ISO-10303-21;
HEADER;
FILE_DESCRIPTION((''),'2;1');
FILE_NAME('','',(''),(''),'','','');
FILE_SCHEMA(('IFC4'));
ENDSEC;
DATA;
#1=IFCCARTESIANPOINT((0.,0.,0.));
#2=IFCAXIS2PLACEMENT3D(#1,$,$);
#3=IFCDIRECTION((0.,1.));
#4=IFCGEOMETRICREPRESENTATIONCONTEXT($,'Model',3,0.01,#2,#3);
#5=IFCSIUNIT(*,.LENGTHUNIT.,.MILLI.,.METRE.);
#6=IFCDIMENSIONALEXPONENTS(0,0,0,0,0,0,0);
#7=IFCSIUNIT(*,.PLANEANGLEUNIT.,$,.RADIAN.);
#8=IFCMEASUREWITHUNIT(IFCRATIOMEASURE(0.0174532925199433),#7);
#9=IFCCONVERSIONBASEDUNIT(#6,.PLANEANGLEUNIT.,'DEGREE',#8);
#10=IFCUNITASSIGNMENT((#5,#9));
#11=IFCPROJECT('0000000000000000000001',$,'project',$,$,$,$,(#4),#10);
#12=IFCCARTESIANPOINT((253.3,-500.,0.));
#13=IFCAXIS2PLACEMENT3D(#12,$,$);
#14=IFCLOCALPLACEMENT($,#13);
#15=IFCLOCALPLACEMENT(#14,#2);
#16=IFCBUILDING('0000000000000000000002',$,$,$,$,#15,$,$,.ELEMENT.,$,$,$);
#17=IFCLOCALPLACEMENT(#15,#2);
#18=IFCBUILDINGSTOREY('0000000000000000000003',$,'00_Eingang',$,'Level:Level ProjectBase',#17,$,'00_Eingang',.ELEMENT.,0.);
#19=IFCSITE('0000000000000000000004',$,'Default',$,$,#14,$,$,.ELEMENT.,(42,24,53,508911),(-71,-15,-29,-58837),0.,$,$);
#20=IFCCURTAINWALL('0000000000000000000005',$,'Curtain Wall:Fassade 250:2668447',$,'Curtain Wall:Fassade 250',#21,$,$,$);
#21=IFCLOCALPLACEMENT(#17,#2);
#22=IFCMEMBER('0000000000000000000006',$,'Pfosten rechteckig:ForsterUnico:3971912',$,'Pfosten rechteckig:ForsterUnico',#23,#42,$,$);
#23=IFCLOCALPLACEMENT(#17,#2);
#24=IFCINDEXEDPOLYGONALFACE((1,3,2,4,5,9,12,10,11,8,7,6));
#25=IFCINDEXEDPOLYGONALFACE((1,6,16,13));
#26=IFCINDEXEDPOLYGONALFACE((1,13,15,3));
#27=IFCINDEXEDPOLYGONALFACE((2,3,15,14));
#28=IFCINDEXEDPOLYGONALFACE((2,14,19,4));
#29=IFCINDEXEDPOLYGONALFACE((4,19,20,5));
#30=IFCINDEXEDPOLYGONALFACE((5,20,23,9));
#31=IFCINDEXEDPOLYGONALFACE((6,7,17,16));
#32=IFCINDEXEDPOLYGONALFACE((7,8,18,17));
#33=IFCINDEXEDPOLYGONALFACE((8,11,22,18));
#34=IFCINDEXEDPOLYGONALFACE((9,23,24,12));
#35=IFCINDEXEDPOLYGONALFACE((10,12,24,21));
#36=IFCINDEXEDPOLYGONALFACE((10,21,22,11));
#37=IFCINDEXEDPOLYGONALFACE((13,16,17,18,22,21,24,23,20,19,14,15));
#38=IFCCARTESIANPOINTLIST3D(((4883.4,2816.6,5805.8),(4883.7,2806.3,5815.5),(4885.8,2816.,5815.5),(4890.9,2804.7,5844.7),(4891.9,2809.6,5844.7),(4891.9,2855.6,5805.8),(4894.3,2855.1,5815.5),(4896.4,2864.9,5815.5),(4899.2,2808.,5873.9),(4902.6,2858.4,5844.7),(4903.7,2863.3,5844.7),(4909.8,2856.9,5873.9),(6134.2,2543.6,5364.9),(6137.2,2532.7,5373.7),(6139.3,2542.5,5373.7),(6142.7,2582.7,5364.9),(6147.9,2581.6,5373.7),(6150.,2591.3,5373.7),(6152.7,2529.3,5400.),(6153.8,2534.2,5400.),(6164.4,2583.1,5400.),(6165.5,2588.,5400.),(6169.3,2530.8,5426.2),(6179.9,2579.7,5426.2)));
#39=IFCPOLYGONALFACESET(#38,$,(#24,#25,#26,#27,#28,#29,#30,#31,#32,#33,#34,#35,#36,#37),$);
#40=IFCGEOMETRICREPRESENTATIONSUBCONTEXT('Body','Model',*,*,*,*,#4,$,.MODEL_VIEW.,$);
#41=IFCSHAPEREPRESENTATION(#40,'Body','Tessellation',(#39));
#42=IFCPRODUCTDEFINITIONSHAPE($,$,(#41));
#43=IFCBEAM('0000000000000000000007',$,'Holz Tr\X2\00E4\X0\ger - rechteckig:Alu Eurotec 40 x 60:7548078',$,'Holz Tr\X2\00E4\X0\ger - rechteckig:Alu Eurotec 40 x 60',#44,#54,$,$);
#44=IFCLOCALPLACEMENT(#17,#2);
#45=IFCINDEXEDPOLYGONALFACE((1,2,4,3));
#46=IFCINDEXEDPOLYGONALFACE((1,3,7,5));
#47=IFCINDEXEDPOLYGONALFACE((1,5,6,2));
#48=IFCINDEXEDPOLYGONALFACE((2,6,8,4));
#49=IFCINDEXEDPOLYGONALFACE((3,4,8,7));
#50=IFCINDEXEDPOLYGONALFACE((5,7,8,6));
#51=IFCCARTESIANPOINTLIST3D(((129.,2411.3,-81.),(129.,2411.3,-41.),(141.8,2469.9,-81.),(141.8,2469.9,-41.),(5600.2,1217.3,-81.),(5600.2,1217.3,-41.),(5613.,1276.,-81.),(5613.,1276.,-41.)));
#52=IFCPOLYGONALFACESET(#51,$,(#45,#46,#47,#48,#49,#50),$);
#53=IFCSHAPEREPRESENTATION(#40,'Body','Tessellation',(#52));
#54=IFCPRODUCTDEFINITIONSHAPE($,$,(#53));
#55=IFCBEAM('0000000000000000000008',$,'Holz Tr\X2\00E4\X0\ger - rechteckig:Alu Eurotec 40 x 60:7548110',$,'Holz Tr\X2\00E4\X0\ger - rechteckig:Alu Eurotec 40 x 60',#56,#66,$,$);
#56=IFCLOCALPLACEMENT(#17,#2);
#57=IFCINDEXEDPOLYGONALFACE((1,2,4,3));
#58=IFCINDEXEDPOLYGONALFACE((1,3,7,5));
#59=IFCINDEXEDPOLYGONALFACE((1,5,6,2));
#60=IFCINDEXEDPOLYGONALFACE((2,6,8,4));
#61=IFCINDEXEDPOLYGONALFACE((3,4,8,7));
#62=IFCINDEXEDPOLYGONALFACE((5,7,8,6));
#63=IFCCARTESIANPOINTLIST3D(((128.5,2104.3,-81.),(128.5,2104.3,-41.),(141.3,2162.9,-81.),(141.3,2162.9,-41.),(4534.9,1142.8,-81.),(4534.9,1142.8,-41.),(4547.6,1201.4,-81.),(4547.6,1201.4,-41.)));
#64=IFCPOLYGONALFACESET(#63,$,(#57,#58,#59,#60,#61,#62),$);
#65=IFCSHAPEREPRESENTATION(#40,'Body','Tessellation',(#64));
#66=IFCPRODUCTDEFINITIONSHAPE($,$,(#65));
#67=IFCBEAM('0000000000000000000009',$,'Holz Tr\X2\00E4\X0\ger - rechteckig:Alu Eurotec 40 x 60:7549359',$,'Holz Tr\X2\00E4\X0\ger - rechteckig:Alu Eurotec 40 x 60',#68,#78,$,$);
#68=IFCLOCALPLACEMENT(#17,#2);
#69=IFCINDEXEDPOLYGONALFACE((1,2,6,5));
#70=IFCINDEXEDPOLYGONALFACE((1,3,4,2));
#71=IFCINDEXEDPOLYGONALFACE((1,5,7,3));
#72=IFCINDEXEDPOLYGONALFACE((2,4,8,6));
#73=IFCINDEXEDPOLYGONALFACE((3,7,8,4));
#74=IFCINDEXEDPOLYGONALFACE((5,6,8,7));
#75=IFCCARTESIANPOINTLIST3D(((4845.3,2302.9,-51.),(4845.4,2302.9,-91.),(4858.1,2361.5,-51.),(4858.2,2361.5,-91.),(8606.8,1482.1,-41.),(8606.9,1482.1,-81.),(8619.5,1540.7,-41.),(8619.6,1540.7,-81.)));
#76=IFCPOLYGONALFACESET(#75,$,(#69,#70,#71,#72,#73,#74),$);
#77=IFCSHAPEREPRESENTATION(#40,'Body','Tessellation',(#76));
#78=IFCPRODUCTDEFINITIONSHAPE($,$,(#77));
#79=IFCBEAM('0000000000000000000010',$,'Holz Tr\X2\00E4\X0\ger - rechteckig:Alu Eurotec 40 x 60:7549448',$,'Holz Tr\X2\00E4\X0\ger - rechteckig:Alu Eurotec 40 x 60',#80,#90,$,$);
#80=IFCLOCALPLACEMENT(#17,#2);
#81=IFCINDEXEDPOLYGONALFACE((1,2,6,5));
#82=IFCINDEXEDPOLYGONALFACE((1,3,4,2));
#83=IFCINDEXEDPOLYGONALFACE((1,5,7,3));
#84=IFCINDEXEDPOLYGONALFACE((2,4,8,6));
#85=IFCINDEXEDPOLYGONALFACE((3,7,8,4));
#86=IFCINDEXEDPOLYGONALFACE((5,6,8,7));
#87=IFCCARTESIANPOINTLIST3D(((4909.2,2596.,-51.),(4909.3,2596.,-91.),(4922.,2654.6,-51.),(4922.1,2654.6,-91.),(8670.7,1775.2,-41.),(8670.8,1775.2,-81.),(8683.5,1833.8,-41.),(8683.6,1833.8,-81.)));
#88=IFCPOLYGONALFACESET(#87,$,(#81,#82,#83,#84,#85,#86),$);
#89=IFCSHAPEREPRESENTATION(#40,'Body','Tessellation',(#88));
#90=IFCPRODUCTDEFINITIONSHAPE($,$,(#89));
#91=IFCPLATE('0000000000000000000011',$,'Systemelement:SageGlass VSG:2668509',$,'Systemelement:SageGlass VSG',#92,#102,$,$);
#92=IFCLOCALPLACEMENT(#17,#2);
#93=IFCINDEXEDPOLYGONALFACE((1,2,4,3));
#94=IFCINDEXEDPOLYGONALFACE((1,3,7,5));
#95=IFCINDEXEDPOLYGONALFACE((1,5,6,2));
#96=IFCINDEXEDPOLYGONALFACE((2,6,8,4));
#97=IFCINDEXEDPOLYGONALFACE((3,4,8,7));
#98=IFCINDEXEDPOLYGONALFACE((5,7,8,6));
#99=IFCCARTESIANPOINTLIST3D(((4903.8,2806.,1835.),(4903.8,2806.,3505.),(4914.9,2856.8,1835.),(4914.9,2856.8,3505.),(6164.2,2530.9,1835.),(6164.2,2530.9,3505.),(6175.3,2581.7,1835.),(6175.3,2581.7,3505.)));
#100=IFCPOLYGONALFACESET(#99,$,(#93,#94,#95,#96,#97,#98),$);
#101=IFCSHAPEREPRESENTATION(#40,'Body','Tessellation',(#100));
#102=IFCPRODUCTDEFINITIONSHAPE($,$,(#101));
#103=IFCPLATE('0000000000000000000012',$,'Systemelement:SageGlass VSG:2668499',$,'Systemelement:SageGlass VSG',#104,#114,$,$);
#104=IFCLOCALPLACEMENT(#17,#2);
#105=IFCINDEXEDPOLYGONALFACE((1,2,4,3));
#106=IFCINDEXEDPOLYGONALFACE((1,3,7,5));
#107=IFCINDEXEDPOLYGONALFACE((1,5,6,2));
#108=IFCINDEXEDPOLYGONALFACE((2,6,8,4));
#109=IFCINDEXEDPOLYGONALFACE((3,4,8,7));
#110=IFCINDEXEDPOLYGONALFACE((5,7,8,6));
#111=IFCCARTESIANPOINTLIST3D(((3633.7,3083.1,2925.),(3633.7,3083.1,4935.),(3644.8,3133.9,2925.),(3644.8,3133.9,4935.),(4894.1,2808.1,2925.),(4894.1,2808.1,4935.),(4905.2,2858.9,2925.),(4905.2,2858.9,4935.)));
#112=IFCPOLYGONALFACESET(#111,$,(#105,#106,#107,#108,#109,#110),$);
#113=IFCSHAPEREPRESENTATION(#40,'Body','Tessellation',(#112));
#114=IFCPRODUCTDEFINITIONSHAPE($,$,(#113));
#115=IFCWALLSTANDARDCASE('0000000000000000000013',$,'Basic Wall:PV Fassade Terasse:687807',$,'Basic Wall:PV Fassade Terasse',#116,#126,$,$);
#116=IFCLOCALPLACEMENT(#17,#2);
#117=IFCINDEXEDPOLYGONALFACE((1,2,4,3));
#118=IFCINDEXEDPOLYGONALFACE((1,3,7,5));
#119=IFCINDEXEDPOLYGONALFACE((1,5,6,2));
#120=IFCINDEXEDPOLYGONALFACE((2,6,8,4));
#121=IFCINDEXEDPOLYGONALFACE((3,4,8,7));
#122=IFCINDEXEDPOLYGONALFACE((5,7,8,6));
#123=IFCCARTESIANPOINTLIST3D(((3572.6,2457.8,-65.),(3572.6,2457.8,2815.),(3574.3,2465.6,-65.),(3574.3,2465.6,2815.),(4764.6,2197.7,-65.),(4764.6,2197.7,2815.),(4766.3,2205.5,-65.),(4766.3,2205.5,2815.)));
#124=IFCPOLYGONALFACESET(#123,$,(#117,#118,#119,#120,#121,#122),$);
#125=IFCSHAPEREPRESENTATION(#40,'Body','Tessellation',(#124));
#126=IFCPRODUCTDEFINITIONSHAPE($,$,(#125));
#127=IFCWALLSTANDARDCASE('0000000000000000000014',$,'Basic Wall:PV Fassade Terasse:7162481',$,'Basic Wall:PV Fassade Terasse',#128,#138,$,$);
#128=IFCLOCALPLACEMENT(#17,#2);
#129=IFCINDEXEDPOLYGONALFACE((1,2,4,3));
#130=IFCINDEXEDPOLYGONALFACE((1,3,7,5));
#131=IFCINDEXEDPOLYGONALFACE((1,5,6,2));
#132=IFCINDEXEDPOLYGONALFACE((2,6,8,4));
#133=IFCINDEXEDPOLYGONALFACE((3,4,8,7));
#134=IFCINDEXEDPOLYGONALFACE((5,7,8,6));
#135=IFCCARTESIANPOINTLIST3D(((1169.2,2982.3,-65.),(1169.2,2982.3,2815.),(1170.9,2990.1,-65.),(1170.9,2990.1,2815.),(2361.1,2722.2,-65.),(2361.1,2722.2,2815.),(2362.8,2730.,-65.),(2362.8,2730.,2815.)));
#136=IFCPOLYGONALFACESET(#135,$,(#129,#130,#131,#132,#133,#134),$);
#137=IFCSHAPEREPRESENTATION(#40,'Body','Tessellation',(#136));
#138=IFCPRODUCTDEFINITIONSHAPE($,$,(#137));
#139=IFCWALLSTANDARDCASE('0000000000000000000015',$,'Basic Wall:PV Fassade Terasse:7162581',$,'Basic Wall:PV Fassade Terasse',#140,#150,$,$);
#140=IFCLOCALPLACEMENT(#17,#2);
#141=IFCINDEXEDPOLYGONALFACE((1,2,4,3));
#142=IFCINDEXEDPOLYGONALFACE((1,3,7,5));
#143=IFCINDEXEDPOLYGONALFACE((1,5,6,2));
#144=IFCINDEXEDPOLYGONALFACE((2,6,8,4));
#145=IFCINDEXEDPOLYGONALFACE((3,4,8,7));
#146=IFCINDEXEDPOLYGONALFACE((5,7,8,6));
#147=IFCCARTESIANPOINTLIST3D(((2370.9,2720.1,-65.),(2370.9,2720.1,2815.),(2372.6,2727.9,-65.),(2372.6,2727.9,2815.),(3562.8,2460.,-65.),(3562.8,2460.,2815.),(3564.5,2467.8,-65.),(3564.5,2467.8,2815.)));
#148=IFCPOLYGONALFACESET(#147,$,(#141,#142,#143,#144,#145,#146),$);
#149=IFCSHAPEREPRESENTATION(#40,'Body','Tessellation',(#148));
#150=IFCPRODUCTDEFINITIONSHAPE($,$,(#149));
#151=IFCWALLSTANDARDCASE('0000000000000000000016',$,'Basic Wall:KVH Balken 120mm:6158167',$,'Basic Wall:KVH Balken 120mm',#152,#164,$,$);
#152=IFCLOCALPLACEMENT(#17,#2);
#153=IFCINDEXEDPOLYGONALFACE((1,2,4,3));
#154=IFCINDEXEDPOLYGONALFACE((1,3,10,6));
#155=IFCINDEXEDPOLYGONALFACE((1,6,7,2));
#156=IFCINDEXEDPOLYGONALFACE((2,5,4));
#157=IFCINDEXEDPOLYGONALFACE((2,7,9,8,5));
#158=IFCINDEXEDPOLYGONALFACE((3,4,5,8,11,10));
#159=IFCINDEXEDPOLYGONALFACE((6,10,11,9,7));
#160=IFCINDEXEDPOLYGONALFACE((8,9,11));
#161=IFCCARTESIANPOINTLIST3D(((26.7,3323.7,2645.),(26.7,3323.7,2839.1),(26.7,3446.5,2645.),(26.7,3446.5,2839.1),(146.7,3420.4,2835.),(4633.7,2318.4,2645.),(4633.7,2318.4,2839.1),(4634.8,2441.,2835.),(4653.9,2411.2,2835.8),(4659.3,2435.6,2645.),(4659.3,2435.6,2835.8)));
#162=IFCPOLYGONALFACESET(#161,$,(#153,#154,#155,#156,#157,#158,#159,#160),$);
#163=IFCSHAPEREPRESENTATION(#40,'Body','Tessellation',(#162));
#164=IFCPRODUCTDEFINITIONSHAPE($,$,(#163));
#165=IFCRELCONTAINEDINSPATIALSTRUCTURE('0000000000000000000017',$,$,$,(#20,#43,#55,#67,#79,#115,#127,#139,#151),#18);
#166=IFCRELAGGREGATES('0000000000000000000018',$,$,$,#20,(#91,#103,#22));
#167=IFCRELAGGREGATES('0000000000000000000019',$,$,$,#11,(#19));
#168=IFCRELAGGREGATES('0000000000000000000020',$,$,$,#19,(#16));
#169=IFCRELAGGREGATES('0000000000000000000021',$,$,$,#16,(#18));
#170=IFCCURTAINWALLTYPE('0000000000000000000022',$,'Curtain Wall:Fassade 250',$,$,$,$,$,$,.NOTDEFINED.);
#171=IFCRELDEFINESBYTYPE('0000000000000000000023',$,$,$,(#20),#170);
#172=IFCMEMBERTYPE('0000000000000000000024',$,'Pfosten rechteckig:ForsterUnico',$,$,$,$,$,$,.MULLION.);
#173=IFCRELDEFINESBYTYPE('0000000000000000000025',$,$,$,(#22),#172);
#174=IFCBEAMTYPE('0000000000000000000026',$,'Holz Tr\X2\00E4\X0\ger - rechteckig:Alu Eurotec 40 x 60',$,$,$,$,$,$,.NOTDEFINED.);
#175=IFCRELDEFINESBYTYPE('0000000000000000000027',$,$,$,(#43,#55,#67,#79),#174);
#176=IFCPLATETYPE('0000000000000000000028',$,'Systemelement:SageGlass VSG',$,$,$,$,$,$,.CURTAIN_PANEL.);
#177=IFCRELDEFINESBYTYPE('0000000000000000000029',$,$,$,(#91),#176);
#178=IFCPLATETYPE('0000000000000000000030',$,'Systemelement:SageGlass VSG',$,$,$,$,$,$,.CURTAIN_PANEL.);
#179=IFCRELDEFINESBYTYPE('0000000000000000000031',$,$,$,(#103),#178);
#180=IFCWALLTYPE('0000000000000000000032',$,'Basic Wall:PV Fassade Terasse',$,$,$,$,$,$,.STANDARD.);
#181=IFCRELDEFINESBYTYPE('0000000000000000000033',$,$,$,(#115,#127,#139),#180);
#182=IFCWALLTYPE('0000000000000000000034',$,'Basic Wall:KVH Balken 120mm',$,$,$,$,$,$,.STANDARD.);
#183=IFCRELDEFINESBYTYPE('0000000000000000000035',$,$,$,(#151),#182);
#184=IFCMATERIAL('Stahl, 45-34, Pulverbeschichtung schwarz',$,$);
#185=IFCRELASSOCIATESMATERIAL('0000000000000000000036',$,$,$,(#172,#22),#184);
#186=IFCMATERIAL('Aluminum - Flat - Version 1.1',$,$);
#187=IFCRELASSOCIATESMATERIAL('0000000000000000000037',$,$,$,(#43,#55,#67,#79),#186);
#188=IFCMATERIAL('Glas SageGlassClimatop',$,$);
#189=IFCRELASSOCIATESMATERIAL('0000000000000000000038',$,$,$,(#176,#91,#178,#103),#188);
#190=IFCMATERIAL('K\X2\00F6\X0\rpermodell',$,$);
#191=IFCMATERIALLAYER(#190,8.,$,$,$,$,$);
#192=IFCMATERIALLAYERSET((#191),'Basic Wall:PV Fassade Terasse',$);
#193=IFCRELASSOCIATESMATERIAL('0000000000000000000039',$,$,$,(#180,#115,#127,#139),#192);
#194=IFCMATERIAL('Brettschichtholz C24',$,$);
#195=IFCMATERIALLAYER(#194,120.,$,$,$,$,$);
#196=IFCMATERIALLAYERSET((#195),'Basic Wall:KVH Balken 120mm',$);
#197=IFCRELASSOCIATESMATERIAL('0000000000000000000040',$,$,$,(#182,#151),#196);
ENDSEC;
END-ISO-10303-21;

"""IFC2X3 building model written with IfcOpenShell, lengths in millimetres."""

from ifc_helpers import new_model, entity, si_unit, converted_unit, direction, frame, frame_2d, origin, place, context, subcontext, project, spatial, polyline, rectangle, outline, extrude, clip, halfspace, bounded_halfspace, source, transform, mapped, material, layer, layer_set, layer_usage, type_object, type_shapes, element, aggregate, save


model = new_model("IFC2X3")

# Units and contexts
model_context = context("Model", 3, precision=0.01, world=origin(), true_north=direction((0.0, 1.0)))
body_context = subcontext(model_context, "Body", "Model", "MODEL_VIEW")
ifc_project = project(units=[si_unit("LENGTHUNIT", "METRE", prefix="MILLI"), converted_unit("PLANEANGLEUNIT", "DEGREE", entity("IfcRatioMeasure", 0.0174532925199433), si_unit("PLANEANGLEUNIT", "RADIAN"), dimensions=[0, 0, 0, 0, 0, 0, 0])], contexts=[model_context])

# Site, building, storey
site_placement = place(None, frame((253.3, -500.0, 0.0)))
site = spatial("IfcSite", under=ifc_project, at=site_placement, Name="Default", CompositionType="ELEMENT", RefLatitude=(42, 24, 53, 508911), RefLongitude=(-71, -15, -29, -58837), RefElevation=0.0)
building_placement = place(site_placement, origin())
building = spatial("IfcBuilding", under=site, at=building_placement, CompositionType="ELEMENT")
storey_placement = place(building_placement, origin())
storey = spatial("IfcBuildingStorey", under=building, at=storey_placement, Name="00_Eingang", ObjectType="Level:Level ProjectBase", LongName="00_Eingang", CompositionType="ELEMENT", Elevation=0.0)

# Curtain wall, member
curtain_wall_type = type_object("IfcCurtainWallType", Name="Curtain Wall:Fassade 250", PredefinedType="NOTDEFINED")
curtain_wall_placement = place(storey_placement, origin())
curtain_wall = element("IfcCurtainWall", 1, at=curtain_wall_placement, inside=storey, type_object=curtain_wall_type, Name="Curtain Wall:Fassade 250:2668447", ObjectType="Curtain Wall:Fassade 250")
ifc_material_1 = material(Name="Stahl, 45-34, Pulverbeschichtung schwarz")
member_type_1 = type_object("IfcMemberType", Name="Pfosten rechteckig:ForsterUnico", PredefinedType="MULLION", material=ifc_material_1)
shared_shape_1 = source(origin(), body_context, "Body", "Clipping", [
    clip(clip(extrude(outline(polyline([(-20.0, -28.3), (20.0, -28.3), (20.0, -18.3), (30.0, -18.3), (30.0, 11.7), (25.0, 11.7), (25.0, 41.7), (-25.0, 41.7), (-25.0, 11.7), (-30.0, 11.7), (-30.0, -18.3), (-20.0, -18.3), (-20.0, -28.3)])), frame((-41.7, 0.0, -1374.9), z_axis=(0.0, 0.0, 1.0), x_axis=(0.0, -1.0, 0.0)), (0.0, 0.0, 1.0), 1374.9), halfspace(frame((0.0, -304.8, -1374.9), z_axis=(-0.210106, 0.0, -0.977679), x_axis=(-0.977679, 0.0, 0.210106)), False)), halfspace(frame((0.0, -304.8, 0.0), z_axis=(-0.083458, 0.0, 0.996511), x_axis=(-0.996511, 0.0, -0.083458)), False)),
])
type_shapes(member_type_1, [shared_shape_1])
member_1_placement = place(storey_placement, frame((4904.5, 2832.4, 5873.9), z_axis=(-0.92378, 0.201585, 0.325568), x_axis=(0.318083, -0.069411, 0.945519)))
member_1 = element("IfcMember", 2, at=member_1_placement, type_object=member_type_1, material=ifc_material_1, Name="Pfosten rechteckig:ForsterUnico:3971912", ObjectType="Pfosten rechteckig:ForsterUnico", context=body_context, shape_type="MappedRepresentation", body=[
    mapped(shared_shape_1, transform((0.0, 0.0, 0.0), scale=1.0)),
])

# Beams
ifc_material_2 = material(Name="Aluminum - Flat - Version 1.1")
beam_type = type_object("IfcBeamType", Name="Holz Träger - rechteckig:Alu Eurotec 40 x 60", PredefinedType="NOTDEFINED")
beam_1_placement = place(storey_placement, frame((135.4, 2440.6, -41.0), z_axis=(0.0, 0.0, 1.0), x_axis=(0.977008, -0.213201, 0.0)))
element("IfcBeam", 3, at=beam_1_placement, inside=storey, type_object=beam_type, material=ifc_material_2, Name="Holz Träger - rechteckig:Alu Eurotec 40 x 60:7548078", ObjectType="Holz Träger - rechteckig:Alu Eurotec 40 x 60", context=body_context, shape_type="SweptSolid", body=[
    extrude(rectangle(XDim=40.0, YDim=60.0, at=frame_2d((0.0, 0.0), x_axis=(1.0, 0.0))), frame((0.0, 0.0, -20.0), z_axis=(1.0, 0.0, 0.0), x_axis=(0.0, 0.0, -1.0)), (0.0, 0.0, 1.0), 5600.0),
])
beam_2_placement = place(storey_placement, frame((134.9, 2133.6, -41.0), z_axis=(0.0, 0.0, 1.0), x_axis=(0.977008, -0.213201, 0.0)))
element("IfcBeam", 4, at=beam_2_placement, inside=storey, type_object=beam_type, material=ifc_material_2, Name="Holz Träger - rechteckig:Alu Eurotec 40 x 60:7548110", ObjectType="Holz Träger - rechteckig:Alu Eurotec 40 x 60", context=body_context, shape_type="SweptSolid", body=[
    extrude(rectangle(XDim=40.0, YDim=60.0, at=frame_2d((0.0, 0.0), x_axis=(1.0, 0.0))), frame((0.0, 0.0, -20.0), z_axis=(1.0, 0.0, 0.0), x_axis=(0.0, 0.0, -1.0)), (0.0, 0.0, 1.0), 4510.0),
])
beam_3_placement = place(storey_placement, frame((4851.7, 2332.2, -51.0), z_axis=(-0.002538, 0.000554, 0.999997), x_axis=(0.977005, -0.2132, 0.002597)))
element("IfcBeam", 5, at=beam_3_placement, inside=storey, type_object=beam_type, material=ifc_material_2, Name="Holz Träger - rechteckig:Alu Eurotec 40 x 60:7549359", ObjectType="Holz Träger - rechteckig:Alu Eurotec 40 x 60", context=body_context, shape_type="SweptSolid", body=[
    extrude(rectangle(XDim=40.0, YDim=60.0, at=frame_2d((0.0, 0.0), x_axis=(1.0, 0.0))), frame((0.0, 0.0, -20.0), z_axis=(1.0, 0.0, 0.0), x_axis=(0.0, 0.0, -1.0)), (0.0, 0.0, 1.0), 3850.0),
])
beam_4_placement = place(storey_placement, frame((4915.6, 2625.3, -51.0), z_axis=(-0.002538, 0.000554, 0.999997), x_axis=(0.977005, -0.2132, 0.002597)))
element("IfcBeam", 6, at=beam_4_placement, inside=storey, type_object=beam_type, material=ifc_material_2, Name="Holz Träger - rechteckig:Alu Eurotec 40 x 60:7549448", ObjectType="Holz Träger - rechteckig:Alu Eurotec 40 x 60", context=body_context, shape_type="SweptSolid", body=[
    extrude(rectangle(XDim=40.0, YDim=60.0, at=frame_2d((0.0, 0.0), x_axis=(1.0, 0.0))), frame((0.0, 0.0, -20.0), z_axis=(1.0, 0.0, 0.0), x_axis=(0.0, 0.0, -1.0)), (0.0, 0.0, 1.0), 3850.0),
])

# Plates
ifc_material_3 = material(Name="Glas SageGlassClimatop")
plate_type_1 = type_object("IfcPlateType", Name="Systemelement:SageGlass VSG", PredefinedType="CURTAIN_PANEL", material=ifc_material_3)
shared_shape_2 = source(origin(), body_context, "Body", "SweptSolid", [
    extrude(rectangle(XDim=1670.0, YDim=1290.0, at=frame_2d((75.8, 0.0), x_axis=(1.0, 0.0))), frame((0.0, -26.0, 759.2), z_axis=(0.0, 1.0, 0.0), x_axis=(0.0, 0.0, 1.0)), (0.0, 0.0, 1.0), 52.0),
])
type_shapes(plate_type_1, [shared_shape_2])
plate_1_placement = place(curtain_wall_placement, frame((5539.5, 2693.8, 1835.0), z_axis=(0.0, 0.0, 1.0), x_axis=(-0.977008, 0.213201, 0.0)))
plate_1 = element("IfcPlate", 7, at=plate_1_placement, type_object=plate_type_1, material=ifc_material_3, Name="Systemelement:SageGlass VSG:2668509", ObjectType="Systemelement:SageGlass VSG", context=body_context, shape_type="MappedRepresentation", body=[
    mapped(shared_shape_2, transform((0.0, 0.0, 0.0), scale=1.0)),
])
plate_type_2 = type_object("IfcPlateType", Name="Systemelement:SageGlass VSG", PredefinedType="CURTAIN_PANEL", material=ifc_material_3)
shared_shape_3 = source(origin(), body_context, "Body", "SweptSolid", [
    extrude(rectangle(XDim=2010.0, YDim=1290.0, at=frame_2d((-146.4, 0.0), x_axis=(1.0, 0.0))), frame((0.0, -26.0, 1151.4), z_axis=(0.0, 1.0, 0.0), x_axis=(0.0, 0.0, 1.0)), (0.0, 0.0, 1.0), 52.0),
])
type_shapes(plate_type_2, [shared_shape_3])
plate_2_placement = place(curtain_wall_placement, frame((4269.4, 2971.0, 2925.0), z_axis=(0.0, 0.0, 1.0), x_axis=(-0.977008, 0.213201, 0.0)))
plate_2 = element("IfcPlate", 8, at=plate_2_placement, type_object=plate_type_2, material=ifc_material_3, Name="Systemelement:SageGlass VSG:2668499", ObjectType="Systemelement:SageGlass VSG", context=body_context, shape_type="MappedRepresentation", body=[
    mapped(shared_shape_3, transform((0.0, 0.0, 0.0), scale=1.0)),
])
aggregate(curtain_wall, [plate_1, plate_2, member_1])

# Walls
ifc_material_4 = material(Name="Körpermodell")
ifc_layer_1 = layer(ifc_material_4, 8.0)
ifc_layer_set_1 = layer_set([ifc_layer_1], Name="Basic Wall:PV Fassade Terasse")
ifc_layer_usage_1 = layer_usage(ifc_layer_set_1, "AXIS2", "NEGATIVE", 4.0)
wall_type_1 = type_object("IfcWallType", Name="Basic Wall:PV Fassade Terasse", PredefinedType="STANDARD", material=ifc_layer_set_1)
wall_1_placement = place(storey_placement, frame((4765.4, 2201.6, -65.0), z_axis=(0.0, 0.0, 1.0), x_axis=(-0.977008, 0.213201, 0.0)))
element("IfcWallStandardCase", 9, at=wall_1_placement, inside=storey, type_object=wall_type_1, material=ifc_layer_usage_1, Name="Basic Wall:PV Fassade Terasse:687807", ObjectType="Basic Wall:PV Fassade Terasse", context=body_context, shape_type="SweptSolid", body=[
    extrude(rectangle(XDim=1220.0, YDim=8.0, at=frame_2d((610.0, 0.0), x_axis=(-1.0, 0.0))), origin(), (0.0, 0.0, 1.0), 2880.0),
])
ifc_layer_usage_2 = layer_usage(ifc_layer_set_1, "AXIS2", "NEGATIVE", 4.0)
wall_2_placement = place(storey_placement, frame((2362.0, 2726.1, -65.0), z_axis=(0.0, 0.0, 1.0), x_axis=(-0.977008, 0.213201, 0.0)))
element("IfcWallStandardCase", 10, at=wall_2_placement, inside=storey, type_object=wall_type_1, material=ifc_layer_usage_2, Name="Basic Wall:PV Fassade Terasse:7162481", ObjectType="Basic Wall:PV Fassade Terasse", context=body_context, shape_type="SweptSolid", body=[
    extrude(rectangle(XDim=1220.0, YDim=8.0, at=frame_2d((610.0, 0.0), x_axis=(-1.0, 0.0))), origin(), (0.0, 0.0, 1.0), 2880.0),
])
ifc_layer_usage_3 = layer_usage(ifc_layer_set_1, "AXIS2", "NEGATIVE", 4.0)
wall_3_placement = place(storey_placement, frame((3563.7, 2463.9, -65.0), z_axis=(0.0, 0.0, 1.0), x_axis=(-0.977008, 0.213201, 0.0)))
element("IfcWallStandardCase", 11, at=wall_3_placement, inside=storey, type_object=wall_type_1, material=ifc_layer_usage_3, Name="Basic Wall:PV Fassade Terasse:7162581", ObjectType="Basic Wall:PV Fassade Terasse", context=body_context, shape_type="SweptSolid", body=[
    extrude(rectangle(XDim=1220.0, YDim=8.0, at=frame_2d((610.0, 0.0), x_axis=(-1.0, 0.0))), origin(), (0.0, 0.0, 1.0), 2880.0),
])
ifc_material_5 = material(Name="Brettschichtholz C24")
ifc_layer_2 = layer(ifc_material_5, 120.0)
ifc_layer_set_2 = layer_set([ifc_layer_2], Name="Basic Wall:KVH Balken 120mm")
ifc_layer_usage_4 = layer_usage(ifc_layer_set_2, "AXIS2", "NEGATIVE", 60.0)
wall_type_2 = type_object("IfcWallType", Name="Basic Wall:KVH Balken 120mm", PredefinedType="STANDARD", material=ifc_layer_set_2)
wall_4_placement = place(storey_placement, frame((4646.5, 2377.0, 2645.0), z_axis=(0.0, 0.0, 1.0), x_axis=(-0.977008, 0.213201, 0.0)))
element("IfcWallStandardCase", 12, at=wall_4_placement, inside=storey, type_object=wall_type_2, material=ifc_layer_usage_4, Name="Basic Wall:KVH Balken 120mm:6158167", ObjectType="Basic Wall:KVH Balken 120mm", context=body_context, shape_type="Clipping", body=[
    clip(clip(clip(extrude(outline(polyline([(4741.6, -60.0), (4715.4, 60.0), (3763.7, 60.0), (0.0, 60.0), (0.0, -60.0), (4618.8, -60.0), (4741.6, -60.0)])), origin(), (0.0, 0.0, 1.0), 194.1), bounded_halfspace(frame((0.0, -60.0, 190.8), z_axis=(-0.034899, 0.0, -0.999391), x_axis=(0.0, 1.0, 0.0)), True, frame((0.0, -60.0, 190.8)), polyline([(0.0, 0.0), (25.0, 0.0), (0.0, 25.0), (0.0, 0.0)]))), bounded_halfspace(frame((25.0, -60.0, 190.0), z_axis=(0.0, 0.034899, -0.999391), x_axis=(1.0, 0.0, 0.0)), True, frame((25.0, -60.0, 190.0)), polyline([(0.0, 0.0), (4593.8, 0.0), (4690.4, 120.0), (-25.0, 120.0), (-25.0, 25.0), (0.0, 0.0)]))), bounded_halfspace(frame((4618.8, -60.0, 190.0), z_axis=(0.034097, 0.007441, -0.999391), x_axis=(0.213201, -0.977008, 0.0)), True, frame((4618.8, -60.0, 190.0)), polyline([(0.0, 0.0), (122.8, 0.0), (96.6, 120.0), (0.0, 0.0)]))),
])

save(model, "model.ifc")
